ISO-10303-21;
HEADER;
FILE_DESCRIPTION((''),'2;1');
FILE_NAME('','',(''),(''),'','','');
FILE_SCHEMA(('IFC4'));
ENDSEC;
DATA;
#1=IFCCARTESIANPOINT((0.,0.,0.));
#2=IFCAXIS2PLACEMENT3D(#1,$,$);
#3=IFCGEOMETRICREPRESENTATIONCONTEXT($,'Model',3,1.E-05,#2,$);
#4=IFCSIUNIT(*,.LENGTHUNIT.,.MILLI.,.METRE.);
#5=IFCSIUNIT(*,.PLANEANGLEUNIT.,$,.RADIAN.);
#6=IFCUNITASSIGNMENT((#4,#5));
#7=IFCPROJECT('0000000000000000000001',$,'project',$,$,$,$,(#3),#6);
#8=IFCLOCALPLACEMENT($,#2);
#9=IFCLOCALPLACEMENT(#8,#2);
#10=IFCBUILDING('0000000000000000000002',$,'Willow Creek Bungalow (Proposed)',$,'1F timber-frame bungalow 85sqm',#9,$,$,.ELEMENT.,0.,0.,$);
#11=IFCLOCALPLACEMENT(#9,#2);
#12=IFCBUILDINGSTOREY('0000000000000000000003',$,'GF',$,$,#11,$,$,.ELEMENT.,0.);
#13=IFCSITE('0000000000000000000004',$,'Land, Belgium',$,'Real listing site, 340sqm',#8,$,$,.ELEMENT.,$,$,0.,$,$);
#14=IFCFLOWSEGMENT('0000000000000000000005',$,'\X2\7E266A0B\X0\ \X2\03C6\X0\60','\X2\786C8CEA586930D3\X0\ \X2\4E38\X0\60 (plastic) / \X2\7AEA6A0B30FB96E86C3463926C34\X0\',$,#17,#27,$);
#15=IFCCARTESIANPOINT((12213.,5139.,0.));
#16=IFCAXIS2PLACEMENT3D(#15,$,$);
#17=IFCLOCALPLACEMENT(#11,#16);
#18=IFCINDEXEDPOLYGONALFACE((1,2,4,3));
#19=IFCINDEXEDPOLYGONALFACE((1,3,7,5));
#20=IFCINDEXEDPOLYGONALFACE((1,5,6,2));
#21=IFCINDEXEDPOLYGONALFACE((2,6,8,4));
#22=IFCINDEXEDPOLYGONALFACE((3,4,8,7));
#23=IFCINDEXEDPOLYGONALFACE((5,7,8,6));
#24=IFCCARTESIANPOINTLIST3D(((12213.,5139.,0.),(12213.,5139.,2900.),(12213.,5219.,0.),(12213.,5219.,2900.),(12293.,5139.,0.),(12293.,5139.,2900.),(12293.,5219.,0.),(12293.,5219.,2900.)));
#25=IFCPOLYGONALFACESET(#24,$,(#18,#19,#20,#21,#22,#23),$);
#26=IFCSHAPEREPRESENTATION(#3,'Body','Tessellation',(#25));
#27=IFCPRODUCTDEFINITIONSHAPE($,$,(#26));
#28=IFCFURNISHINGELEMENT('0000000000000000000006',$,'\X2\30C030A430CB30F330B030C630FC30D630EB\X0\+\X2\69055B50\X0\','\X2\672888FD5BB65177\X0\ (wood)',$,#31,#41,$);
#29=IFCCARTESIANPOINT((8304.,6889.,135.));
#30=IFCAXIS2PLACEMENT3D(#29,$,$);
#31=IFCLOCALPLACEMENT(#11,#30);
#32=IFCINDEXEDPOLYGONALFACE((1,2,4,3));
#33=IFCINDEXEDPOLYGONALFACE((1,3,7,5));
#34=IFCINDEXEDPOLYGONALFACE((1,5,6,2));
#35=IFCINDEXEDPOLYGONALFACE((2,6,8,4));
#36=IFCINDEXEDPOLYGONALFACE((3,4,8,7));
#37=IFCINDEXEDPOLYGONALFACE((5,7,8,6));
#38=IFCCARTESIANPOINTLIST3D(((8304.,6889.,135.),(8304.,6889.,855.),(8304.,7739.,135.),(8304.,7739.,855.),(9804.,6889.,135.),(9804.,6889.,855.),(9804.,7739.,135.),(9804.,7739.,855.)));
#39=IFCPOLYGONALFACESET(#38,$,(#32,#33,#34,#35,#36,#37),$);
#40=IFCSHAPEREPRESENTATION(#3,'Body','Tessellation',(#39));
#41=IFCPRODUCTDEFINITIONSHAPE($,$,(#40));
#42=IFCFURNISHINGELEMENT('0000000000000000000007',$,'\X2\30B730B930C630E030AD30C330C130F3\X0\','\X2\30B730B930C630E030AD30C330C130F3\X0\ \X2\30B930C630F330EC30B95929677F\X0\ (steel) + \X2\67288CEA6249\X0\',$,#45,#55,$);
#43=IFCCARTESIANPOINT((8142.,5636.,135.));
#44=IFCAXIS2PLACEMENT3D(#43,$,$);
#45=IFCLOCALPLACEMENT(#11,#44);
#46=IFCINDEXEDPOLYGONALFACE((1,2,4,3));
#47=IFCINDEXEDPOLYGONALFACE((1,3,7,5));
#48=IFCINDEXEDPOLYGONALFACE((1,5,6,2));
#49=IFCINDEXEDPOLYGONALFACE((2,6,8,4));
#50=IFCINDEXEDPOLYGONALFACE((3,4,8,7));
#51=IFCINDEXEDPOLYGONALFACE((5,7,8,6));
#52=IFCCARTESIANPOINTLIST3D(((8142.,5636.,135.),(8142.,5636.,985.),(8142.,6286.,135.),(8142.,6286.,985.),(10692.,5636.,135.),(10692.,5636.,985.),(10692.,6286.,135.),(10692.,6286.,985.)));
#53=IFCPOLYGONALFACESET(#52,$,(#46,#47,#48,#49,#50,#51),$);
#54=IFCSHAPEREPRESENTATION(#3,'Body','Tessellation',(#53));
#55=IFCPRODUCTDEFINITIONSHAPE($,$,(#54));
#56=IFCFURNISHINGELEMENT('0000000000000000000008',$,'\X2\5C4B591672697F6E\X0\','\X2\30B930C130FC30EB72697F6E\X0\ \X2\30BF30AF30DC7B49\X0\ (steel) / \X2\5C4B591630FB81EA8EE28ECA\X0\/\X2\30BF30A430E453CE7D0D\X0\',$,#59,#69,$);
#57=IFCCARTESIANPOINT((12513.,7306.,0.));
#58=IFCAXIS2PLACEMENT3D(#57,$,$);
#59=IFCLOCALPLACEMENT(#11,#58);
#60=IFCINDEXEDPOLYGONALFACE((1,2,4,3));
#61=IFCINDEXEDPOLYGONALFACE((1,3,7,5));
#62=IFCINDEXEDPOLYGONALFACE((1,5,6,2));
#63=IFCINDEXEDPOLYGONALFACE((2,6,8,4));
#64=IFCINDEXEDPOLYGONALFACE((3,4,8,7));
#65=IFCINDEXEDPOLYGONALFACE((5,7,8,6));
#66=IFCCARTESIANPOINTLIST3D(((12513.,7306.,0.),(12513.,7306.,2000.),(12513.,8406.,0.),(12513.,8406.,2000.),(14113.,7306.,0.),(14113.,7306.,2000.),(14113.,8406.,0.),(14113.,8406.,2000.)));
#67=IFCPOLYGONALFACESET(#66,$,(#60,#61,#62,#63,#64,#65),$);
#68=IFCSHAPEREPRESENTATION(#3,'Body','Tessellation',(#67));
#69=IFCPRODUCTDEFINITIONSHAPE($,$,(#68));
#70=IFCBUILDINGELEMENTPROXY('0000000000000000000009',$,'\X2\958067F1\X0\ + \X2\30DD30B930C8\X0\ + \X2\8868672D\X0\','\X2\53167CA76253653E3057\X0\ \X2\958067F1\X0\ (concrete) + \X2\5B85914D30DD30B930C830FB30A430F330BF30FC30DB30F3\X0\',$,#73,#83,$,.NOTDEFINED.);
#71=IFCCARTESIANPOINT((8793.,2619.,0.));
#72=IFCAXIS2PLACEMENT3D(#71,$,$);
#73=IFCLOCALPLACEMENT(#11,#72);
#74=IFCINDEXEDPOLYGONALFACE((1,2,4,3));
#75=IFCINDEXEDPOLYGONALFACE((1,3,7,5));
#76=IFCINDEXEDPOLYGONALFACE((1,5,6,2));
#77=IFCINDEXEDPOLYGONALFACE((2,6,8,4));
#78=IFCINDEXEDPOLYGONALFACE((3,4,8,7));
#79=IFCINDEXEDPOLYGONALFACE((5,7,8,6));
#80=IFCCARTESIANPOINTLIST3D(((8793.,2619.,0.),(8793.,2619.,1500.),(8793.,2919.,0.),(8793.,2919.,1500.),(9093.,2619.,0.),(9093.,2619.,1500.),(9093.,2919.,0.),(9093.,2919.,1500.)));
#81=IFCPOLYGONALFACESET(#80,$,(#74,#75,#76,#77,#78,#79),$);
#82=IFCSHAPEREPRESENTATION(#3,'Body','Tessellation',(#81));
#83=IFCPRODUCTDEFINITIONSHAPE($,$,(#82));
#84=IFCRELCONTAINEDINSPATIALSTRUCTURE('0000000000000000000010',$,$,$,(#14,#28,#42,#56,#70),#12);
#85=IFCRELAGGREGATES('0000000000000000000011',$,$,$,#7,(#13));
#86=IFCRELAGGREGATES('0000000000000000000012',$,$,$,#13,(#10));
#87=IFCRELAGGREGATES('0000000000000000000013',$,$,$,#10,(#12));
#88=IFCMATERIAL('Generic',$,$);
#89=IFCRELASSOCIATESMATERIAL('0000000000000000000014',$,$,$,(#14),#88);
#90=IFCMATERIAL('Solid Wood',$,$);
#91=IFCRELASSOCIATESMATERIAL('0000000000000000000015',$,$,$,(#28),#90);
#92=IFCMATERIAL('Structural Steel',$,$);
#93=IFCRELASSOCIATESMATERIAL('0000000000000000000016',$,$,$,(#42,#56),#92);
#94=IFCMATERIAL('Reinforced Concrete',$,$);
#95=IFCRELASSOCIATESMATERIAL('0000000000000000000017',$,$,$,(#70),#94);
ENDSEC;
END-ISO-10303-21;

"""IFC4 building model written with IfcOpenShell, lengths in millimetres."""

from ifc_helpers import new_model, si_unit, frame, frame_2d, origin, place, context, project, spatial, rectangle, extrude, material, element, save


model = new_model("IFC4")

# Units and contexts
model_context = context("Model", 3, precision=1e-05, world=origin())
ifc_project = project(units=[si_unit("LENGTHUNIT", "METRE", prefix="MILLI"), si_unit("PLANEANGLEUNIT", "RADIAN")], contexts=[model_context])

# Site, building, storey
site_placement = place(None, origin())
site = spatial("IfcSite", under=ifc_project, at=site_placement, Name="Land, Belgium", ObjectType="Real listing site, 340sqm", CompositionType="ELEMENT", RefElevation=0.0)
building_placement = place(site_placement, origin())
building = spatial("IfcBuilding", under=site, at=building_placement, Name="Willow Creek Bungalow (Proposed)", ObjectType="1F timber-frame bungalow 85sqm", CompositionType="ELEMENT", ElevationOfRefHeight=0.0, ElevationOfTerrain=0.0)
storey_placement = place(building_placement, origin())
storey = spatial("IfcBuildingStorey", under=building, at=storey_placement, Name="GF", CompositionType="ELEMENT", Elevation=0.0)

# Shared definitions
ifc_material_1 = material(Name="Solid Wood")

# Shared definitions
ifc_material_2 = material(Name="Structural Steel")

# Shared definitions
ifc_material_3 = material(Name="Reinforced Concrete")

# Shared definitions
ifc_material_4 = material(Name="Generic")

# Flow segment
flow_segment_placement = place(storey_placement, frame((12213.0, 5139.0, 0.0)))
element("IfcFlowSegment", 1, at=flow_segment_placement, inside=storey, material=ifc_material_4, Name="縦樋 φ60", Description="硬質塩ビ 丸60 (plastic) / 竪樋・雨水排水", context=model_context, shape_type="SweptSolid", body=[
    extrude(rectangle(XDim=80.0, YDim=80.0, at=frame_2d((40.0, 40.0))), frame((12213.0, 5139.0, 0.0)), (0.0, 0.0, 1.0), 2900.0),
])

# Furnishing elements
furnishing_1_placement = place(storey_placement, frame((8304.0, 6889.0, 135.0)))
element("IfcFurnishingElement", 2, at=furnishing_1_placement, inside=storey, material=ifc_material_1, Name="ダイニングテーブル+椅子", Description="木製家具 (wood)", context=model_context, shape_type="SweptSolid", body=[
    extrude(rectangle(XDim=1500.0, YDim=850.0, at=frame_2d((750.0, 425.0))), frame((8304.0, 6889.0, 135.0)), (0.0, 0.0, 1.0), 720.0),
])
furnishing_2_placement = place(storey_placement, frame((8142.0, 5636.0, 135.0)))
element("IfcFurnishingElement", 3, at=furnishing_2_placement, inside=storey, material=ifc_material_2, Name="システムキッチン", Description="システムキッチン ステンレス天板 (steel) + 木質扉", context=model_context, shape_type="SweptSolid", body=[
    extrude(rectangle(XDim=2550.0, YDim=650.0, at=frame_2d((1275.0, 325.0))), frame((8142.0, 5636.0, 135.0)), (0.0, 0.0, 1.0), 850.0),
])
furnishing_3_placement = place(storey_placement, frame((12513.0, 7306.0, 0.0)))
element("IfcFurnishingElement", 4, at=furnishing_3_placement, inside=storey, material=ifc_material_2, Name="屋外物置", Description="スチール物置 タクボ等 (steel) / 屋外・自転車/タイヤ収納", context=model_context, shape_type="SweptSolid", body=[
    extrude(rectangle(XDim=1600.0, YDim=1100.0, at=frame_2d((800.0, 550.0))), frame((12513.0, 7306.0, 0.0)), (0.0, 0.0, 1.0), 2000.0),
])

# Building element proxy
proxy_placement = place(storey_placement, frame((8793.0, 2619.0, 0.0)))
element("IfcBuildingElementProxy", 5, at=proxy_placement, inside=storey, material=ifc_material_3, Name="門柱 + ポスト + 表札", Description="化粧打放し 門柱 (concrete) + 宅配ポスト・インターホン", PredefinedType="NOTDEFINED", context=model_context, shape_type="SweptSolid", body=[
    extrude(rectangle(XDim=300.0, YDim=300.0, at=frame_2d((150.0, 150.0))), frame((8793.0, 2619.0, 0.0)), (0.0, 0.0, 1.0), 1500.0),
])

save(model, "model.ifc")
